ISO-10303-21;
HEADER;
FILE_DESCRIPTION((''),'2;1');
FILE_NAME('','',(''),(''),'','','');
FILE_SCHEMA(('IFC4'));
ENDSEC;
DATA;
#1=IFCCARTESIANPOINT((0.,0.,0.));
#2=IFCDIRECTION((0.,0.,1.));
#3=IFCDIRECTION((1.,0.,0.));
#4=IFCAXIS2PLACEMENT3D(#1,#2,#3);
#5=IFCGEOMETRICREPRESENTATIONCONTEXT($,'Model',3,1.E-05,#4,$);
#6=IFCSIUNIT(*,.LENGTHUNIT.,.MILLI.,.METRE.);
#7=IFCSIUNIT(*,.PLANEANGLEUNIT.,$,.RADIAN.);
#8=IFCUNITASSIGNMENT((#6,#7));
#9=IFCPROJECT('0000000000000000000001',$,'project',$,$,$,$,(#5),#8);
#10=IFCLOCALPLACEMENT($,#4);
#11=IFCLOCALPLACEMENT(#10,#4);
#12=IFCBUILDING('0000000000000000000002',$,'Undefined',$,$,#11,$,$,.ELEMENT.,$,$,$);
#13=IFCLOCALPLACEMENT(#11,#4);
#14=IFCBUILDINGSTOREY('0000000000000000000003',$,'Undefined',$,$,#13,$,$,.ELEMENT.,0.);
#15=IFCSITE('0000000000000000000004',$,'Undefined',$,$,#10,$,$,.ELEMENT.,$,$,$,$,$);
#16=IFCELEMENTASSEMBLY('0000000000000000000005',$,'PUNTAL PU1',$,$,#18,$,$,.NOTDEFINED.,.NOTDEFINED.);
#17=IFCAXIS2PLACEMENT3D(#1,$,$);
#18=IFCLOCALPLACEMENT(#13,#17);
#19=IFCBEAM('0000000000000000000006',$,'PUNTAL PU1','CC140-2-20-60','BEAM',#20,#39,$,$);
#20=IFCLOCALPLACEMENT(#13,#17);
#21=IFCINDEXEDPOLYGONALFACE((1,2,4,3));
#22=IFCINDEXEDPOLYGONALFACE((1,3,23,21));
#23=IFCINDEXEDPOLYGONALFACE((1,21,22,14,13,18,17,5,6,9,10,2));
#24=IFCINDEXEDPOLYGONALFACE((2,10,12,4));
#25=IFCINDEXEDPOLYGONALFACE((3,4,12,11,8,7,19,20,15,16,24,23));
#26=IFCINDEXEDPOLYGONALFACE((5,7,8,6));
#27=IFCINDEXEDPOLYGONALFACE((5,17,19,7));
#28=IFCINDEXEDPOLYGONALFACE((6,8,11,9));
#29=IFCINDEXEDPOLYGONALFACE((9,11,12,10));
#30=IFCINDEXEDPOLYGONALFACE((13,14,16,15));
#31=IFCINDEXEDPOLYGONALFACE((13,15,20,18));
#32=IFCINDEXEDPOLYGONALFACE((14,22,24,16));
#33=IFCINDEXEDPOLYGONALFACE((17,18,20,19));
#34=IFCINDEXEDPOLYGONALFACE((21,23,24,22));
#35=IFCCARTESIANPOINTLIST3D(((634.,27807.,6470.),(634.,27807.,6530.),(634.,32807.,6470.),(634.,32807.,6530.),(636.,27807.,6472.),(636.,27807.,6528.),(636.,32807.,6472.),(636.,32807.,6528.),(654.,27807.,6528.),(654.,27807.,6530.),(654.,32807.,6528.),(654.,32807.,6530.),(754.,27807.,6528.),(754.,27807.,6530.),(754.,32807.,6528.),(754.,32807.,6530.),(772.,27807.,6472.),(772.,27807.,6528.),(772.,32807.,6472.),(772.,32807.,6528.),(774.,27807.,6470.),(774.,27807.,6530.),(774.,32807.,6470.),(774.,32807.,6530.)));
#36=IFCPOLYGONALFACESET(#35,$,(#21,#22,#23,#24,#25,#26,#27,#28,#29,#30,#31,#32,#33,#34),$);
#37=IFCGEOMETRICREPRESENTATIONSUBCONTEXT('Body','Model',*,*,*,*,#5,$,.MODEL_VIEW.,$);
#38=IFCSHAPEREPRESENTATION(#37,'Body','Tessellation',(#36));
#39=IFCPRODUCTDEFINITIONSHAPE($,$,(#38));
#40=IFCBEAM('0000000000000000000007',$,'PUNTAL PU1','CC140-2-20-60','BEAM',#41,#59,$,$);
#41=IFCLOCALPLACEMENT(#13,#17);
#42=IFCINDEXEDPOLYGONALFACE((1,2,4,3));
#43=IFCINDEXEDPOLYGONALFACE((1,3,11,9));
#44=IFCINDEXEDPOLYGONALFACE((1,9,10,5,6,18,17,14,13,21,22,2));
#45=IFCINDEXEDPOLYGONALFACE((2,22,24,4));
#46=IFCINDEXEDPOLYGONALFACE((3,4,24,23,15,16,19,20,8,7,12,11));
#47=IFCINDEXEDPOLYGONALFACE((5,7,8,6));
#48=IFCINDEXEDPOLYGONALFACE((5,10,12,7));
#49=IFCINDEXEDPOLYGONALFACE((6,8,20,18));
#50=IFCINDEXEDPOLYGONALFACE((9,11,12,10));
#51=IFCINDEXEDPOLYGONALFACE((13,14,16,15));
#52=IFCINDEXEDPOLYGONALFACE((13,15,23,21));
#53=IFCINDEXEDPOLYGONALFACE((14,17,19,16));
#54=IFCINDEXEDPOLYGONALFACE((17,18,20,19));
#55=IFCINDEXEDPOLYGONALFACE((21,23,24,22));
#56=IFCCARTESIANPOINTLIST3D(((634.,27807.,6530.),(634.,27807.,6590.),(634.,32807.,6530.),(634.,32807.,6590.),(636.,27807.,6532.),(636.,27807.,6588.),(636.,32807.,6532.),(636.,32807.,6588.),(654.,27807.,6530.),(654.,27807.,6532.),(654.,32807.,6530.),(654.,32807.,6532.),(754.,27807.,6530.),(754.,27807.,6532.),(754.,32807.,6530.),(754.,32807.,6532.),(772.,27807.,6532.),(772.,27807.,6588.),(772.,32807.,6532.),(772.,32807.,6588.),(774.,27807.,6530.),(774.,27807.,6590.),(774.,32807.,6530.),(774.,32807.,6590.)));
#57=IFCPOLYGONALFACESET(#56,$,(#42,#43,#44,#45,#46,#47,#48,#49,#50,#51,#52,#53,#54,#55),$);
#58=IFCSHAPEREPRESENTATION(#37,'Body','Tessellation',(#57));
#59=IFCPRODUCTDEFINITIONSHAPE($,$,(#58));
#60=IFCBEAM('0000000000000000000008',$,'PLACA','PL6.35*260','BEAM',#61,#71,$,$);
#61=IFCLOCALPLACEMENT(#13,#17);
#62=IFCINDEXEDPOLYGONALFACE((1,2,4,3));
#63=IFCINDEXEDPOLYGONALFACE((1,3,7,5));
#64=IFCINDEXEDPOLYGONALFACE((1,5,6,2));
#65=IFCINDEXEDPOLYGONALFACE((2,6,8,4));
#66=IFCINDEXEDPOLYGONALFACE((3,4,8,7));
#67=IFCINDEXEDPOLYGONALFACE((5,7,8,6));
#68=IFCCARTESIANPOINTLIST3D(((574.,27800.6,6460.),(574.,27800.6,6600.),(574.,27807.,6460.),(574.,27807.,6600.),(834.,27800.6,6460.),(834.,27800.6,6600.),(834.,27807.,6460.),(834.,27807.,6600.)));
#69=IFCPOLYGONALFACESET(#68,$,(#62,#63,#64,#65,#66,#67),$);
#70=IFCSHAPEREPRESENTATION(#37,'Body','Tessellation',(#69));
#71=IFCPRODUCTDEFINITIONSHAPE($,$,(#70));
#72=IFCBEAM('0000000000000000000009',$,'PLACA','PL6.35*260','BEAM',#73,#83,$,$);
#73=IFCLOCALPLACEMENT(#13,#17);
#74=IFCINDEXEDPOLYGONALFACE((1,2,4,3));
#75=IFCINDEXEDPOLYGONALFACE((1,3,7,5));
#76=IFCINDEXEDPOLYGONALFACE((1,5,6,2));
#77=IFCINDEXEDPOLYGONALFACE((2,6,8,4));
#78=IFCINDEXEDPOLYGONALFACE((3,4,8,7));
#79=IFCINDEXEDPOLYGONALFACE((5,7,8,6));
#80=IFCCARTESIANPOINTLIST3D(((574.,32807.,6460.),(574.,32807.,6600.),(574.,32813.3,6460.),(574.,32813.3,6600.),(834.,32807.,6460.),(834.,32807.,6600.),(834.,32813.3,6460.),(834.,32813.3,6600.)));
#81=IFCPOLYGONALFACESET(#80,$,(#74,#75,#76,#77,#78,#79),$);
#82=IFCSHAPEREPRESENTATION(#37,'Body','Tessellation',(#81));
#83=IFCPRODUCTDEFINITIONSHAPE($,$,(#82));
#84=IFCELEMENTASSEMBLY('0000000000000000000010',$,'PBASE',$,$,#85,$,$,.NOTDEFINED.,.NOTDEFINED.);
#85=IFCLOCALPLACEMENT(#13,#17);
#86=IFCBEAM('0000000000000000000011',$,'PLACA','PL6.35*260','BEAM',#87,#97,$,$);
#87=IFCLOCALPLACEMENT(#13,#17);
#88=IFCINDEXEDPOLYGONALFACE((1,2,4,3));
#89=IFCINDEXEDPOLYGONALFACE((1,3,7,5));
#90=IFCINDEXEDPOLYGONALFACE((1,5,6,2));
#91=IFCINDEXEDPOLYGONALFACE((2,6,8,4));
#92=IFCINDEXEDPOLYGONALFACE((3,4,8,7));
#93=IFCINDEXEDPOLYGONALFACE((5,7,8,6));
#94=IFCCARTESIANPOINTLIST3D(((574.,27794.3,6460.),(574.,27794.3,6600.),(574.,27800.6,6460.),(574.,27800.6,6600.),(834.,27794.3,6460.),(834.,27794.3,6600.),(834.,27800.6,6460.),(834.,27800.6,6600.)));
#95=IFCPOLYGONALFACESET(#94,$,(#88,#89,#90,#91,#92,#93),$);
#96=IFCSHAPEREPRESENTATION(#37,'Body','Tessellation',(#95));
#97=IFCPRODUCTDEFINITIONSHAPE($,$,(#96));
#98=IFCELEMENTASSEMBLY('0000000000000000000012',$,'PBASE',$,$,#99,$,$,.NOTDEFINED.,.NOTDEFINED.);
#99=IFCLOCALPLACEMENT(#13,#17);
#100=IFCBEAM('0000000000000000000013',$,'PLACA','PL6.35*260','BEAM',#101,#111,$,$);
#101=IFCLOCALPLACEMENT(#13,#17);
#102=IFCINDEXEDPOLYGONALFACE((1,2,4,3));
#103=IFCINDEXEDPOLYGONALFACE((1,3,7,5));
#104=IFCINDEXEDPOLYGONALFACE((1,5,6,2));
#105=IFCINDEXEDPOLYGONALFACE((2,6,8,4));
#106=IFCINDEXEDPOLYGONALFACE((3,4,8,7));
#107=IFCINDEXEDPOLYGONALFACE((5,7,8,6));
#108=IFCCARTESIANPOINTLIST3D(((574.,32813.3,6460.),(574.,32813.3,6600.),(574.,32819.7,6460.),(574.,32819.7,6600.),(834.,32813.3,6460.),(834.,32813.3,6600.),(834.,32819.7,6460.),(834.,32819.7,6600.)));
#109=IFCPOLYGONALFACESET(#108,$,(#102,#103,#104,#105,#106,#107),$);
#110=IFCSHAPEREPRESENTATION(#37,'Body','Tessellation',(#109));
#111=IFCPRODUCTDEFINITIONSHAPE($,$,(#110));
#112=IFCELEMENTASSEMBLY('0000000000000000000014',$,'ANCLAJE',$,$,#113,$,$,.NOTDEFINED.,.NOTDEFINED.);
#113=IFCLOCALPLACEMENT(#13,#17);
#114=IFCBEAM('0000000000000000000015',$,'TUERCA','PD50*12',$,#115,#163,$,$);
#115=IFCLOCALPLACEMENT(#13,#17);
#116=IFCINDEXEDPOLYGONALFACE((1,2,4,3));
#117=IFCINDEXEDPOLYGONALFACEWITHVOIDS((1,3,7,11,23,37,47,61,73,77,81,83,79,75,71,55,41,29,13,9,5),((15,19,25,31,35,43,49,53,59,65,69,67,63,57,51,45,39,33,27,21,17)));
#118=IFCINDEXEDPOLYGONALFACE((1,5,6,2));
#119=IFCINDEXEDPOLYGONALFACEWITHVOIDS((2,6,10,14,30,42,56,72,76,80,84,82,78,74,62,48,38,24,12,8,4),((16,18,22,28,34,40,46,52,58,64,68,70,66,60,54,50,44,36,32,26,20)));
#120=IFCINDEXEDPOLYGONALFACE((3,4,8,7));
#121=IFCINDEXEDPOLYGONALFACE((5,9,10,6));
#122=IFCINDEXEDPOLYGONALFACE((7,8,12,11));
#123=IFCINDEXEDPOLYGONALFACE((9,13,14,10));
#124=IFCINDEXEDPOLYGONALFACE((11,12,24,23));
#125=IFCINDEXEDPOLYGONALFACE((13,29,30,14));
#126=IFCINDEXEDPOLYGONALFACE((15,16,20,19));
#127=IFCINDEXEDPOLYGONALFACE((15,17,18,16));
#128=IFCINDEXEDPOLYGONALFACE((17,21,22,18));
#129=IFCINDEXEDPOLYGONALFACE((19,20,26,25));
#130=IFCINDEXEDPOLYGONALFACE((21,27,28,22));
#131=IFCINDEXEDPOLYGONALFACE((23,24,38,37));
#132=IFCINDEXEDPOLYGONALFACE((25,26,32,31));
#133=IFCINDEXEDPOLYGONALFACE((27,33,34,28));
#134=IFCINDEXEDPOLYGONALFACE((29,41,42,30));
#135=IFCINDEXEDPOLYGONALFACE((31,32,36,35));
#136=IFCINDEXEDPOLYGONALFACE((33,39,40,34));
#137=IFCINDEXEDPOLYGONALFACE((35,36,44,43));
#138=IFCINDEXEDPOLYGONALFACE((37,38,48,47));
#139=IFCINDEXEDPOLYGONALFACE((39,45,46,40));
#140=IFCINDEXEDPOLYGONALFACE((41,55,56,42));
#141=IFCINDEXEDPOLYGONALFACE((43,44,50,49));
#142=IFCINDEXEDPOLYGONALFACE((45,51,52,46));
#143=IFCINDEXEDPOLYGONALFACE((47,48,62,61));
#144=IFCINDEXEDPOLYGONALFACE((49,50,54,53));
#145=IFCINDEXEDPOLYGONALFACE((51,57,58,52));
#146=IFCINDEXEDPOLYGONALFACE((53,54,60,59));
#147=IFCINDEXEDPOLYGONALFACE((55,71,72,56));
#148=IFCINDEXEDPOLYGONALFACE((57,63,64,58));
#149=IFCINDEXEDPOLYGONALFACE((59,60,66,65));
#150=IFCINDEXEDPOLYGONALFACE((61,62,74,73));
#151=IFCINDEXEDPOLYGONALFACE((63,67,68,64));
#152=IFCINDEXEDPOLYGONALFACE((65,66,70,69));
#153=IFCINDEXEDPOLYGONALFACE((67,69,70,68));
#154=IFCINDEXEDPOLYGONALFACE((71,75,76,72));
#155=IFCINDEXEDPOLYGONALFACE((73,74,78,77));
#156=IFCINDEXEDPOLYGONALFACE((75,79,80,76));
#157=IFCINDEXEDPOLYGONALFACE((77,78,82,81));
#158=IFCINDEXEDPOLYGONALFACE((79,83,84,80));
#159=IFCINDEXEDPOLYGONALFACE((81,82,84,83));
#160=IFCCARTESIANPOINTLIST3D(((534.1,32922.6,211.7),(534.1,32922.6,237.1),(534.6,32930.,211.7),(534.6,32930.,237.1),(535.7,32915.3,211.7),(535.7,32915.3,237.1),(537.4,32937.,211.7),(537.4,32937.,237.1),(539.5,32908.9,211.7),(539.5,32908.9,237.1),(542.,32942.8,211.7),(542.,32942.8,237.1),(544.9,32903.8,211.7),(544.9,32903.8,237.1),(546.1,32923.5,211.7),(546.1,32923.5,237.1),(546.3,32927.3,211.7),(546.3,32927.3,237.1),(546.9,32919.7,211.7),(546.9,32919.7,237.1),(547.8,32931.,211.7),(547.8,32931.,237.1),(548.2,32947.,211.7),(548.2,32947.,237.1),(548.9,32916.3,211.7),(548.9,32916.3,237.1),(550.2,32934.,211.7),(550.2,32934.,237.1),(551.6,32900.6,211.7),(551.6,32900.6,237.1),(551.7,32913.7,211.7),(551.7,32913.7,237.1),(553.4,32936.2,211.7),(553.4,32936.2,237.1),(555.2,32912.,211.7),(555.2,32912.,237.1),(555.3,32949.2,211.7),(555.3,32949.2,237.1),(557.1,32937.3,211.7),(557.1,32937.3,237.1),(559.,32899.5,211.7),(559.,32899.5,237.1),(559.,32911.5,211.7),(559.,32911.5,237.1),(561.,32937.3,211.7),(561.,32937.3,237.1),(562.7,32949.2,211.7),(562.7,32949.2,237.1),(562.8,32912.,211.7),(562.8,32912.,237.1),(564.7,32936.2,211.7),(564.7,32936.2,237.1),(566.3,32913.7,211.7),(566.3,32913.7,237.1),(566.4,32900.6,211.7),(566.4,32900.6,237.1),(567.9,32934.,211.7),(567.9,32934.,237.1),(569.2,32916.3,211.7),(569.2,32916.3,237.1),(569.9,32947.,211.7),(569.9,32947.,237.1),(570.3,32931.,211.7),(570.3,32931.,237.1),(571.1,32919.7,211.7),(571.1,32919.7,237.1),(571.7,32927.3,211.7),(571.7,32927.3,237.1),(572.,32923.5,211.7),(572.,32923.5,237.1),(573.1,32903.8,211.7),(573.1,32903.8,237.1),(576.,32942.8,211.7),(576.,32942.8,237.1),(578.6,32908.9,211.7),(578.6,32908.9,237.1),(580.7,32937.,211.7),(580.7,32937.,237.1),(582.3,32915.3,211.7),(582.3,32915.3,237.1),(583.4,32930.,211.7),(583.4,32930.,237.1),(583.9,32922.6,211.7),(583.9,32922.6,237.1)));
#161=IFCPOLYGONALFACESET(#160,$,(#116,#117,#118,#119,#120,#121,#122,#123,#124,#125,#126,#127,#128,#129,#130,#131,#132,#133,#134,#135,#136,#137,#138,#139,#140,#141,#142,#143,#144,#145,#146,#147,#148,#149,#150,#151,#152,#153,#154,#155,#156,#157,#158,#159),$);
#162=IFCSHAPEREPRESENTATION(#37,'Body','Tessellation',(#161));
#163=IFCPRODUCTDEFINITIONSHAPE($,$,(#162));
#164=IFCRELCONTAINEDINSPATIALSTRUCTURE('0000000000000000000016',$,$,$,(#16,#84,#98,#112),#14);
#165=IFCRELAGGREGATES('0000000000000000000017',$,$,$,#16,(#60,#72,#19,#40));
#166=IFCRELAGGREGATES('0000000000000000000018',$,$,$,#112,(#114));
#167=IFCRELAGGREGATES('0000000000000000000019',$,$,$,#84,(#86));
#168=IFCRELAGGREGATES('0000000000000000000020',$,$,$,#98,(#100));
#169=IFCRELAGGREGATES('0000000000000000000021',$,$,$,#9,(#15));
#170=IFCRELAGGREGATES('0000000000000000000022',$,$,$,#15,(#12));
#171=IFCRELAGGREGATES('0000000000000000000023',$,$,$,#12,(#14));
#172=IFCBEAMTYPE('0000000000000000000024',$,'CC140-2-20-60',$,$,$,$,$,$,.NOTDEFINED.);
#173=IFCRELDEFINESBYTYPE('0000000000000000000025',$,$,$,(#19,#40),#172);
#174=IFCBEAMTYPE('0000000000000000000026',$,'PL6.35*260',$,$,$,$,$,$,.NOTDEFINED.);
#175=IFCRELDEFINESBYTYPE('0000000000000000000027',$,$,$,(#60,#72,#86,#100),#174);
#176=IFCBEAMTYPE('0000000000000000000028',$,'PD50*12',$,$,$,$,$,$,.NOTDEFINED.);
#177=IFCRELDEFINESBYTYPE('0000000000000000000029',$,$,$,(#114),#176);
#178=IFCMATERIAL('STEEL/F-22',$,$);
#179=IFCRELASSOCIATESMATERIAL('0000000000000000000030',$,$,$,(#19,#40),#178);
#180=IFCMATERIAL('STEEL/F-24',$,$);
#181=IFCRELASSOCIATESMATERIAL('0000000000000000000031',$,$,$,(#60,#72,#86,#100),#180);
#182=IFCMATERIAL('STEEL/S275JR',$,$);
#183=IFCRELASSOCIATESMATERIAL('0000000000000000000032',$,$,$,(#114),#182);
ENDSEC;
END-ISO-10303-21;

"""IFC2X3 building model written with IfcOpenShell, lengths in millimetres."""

from ifc_helpers import new_model, si_unit, frame, origin_with_axes, origin_2d_with_axis, place, context, subcontext, project, spatial, rectangle, hollow_circle, c_section, extrude, material, type_object, element, aggregate, save


model = new_model("IFC2X3")

# Units and contexts
model_context = context("Model", 3, precision=1e-05, world=origin_with_axes())
body_context = subcontext(model_context, "Body", "Model", "MODEL_VIEW")
ifc_project = project(units=[si_unit("LENGTHUNIT", "METRE", prefix="MILLI"), si_unit("PLANEANGLEUNIT", "RADIAN")], contexts=[model_context])

# Site, building, storey
site_placement = place(None, origin_with_axes())
site = spatial("IfcSite", under=ifc_project, at=site_placement, Name="Undefined", CompositionType="ELEMENT")
building_placement = place(site_placement, origin_with_axes())
building = spatial("IfcBuilding", under=site, at=building_placement, Name="Undefined", CompositionType="ELEMENT")
storey_placement = place(building_placement, origin_with_axes())
storey = spatial("IfcBuildingStorey", under=building, at=storey_placement, Name="Undefined", CompositionType="ELEMENT", Elevation=0.0)

# Element assembly, beams
assembly_1_placement = place(storey_placement, origin_with_axes())
assembly_1 = element("IfcElementAssembly", 1, at=assembly_1_placement, inside=storey, Name="PUNTAL PU1", AssemblyPlace="NOTDEFINED", PredefinedType="NOTDEFINED")
ifc_material_1 = material(Name="STEEL/F-22")
beam_type_1 = type_object("IfcBeamType", Name="CC140-2-20-60", PredefinedType="NOTDEFINED")
beam_1_placement = place(assembly_1_placement, frame((704.0, 32807.0, 6500.0), z_axis=(1.0, 0.0, 0.0), x_axis=(0.0, -1.0, 0.0)))
beam_1 = element("IfcBeam", 2, at=beam_1_placement, type_object=beam_type_1, material=ifc_material_1, Name="PUNTAL PU1", Description="CC140-2-20-60", ObjectType="BEAM", context=body_context, shape_type="SweptSolid", body=[
    extrude(c_section(Depth=140.0, Width=60.0, WallThickness=2.0, Girth=20.0, at=origin_2d_with_axis()), frame((5000.0, 0.0, 0.0), z_axis=(-1.0, 0.0, 0.0), x_axis=(0.0, -1.0, 0.0)), (0.0, 0.0, 1.0), 5000.0),
])
beam_2_placement = place(assembly_1_placement, frame((704.0, 32807.0, 6560.0), z_axis=(-1.0, 0.0, 0.0), x_axis=(0.0, -1.0, 0.0)))
beam_2 = element("IfcBeam", 3, at=beam_2_placement, type_object=beam_type_1, material=ifc_material_1, Name="PUNTAL PU1", Description="CC140-2-20-60", ObjectType="BEAM", context=body_context, shape_type="SweptSolid", body=[
    extrude(c_section(Depth=140.0, Width=60.0, WallThickness=2.0, Girth=20.0, at=origin_2d_with_axis()), frame((5000.0, 0.0, 0.0), z_axis=(-1.0, 0.0, 0.0), x_axis=(0.0, -1.0, 0.0)), (0.0, 0.0, 1.0), 5000.0),
])
ifc_material_2 = material(Name="STEEL/F-24")
beam_type_2 = type_object("IfcBeamType", Name="PL6.35*260", PredefinedType="NOTDEFINED")
beam_3_placement = place(assembly_1_placement, frame((704.0, 27803.8, 6460.0), z_axis=(1.0, 0.0, 0.0), x_axis=(0.0, 0.0, 1.0)))
beam_3 = element("IfcBeam", 4, at=beam_3_placement, type_object=beam_type_2, material=ifc_material_2, Name="PLACA", Description="PL6.35*260", ObjectType="BEAM", context=body_context, shape_type="SweptSolid", body=[
    extrude(rectangle(XDim=6.3, YDim=260.0, at=origin_2d_with_axis()), frame((140.0, 0.0, 0.0), z_axis=(-1.0, 0.0, 0.0), x_axis=(0.0, -1.0, 0.0)), (0.0, 0.0, 1.0), 140.0),
])
beam_4_placement = place(assembly_1_placement, frame((704.0, 32810.1, 6460.0), z_axis=(-1.0, 0.0, 0.0), x_axis=(0.0, 0.0, 1.0)))
beam_4 = element("IfcBeam", 5, at=beam_4_placement, type_object=beam_type_2, material=ifc_material_2, Name="PLACA", Description="PL6.35*260", ObjectType="BEAM", context=body_context, shape_type="SweptSolid", body=[
    extrude(rectangle(XDim=6.3, YDim=260.0, at=origin_2d_with_axis()), frame((140.0, 0.0, 0.0), z_axis=(-1.0, 0.0, 0.0), x_axis=(0.0, -1.0, 0.0)), (0.0, 0.0, 1.0), 140.0),
])
aggregate(assembly_1, [beam_3, beam_4, beam_1, beam_2])

# Element assemblies, beams
assembly_2_placement = place(storey_placement, origin_with_axes())
assembly_2 = element("IfcElementAssembly", 6, at=assembly_2_placement, inside=storey, Name="PBASE", AssemblyPlace="NOTDEFINED", PredefinedType="NOTDEFINED")
beam_5_placement = place(assembly_2_placement, frame((704.0, 27797.4, 6460.0), z_axis=(1.0, 0.0, 0.0), x_axis=(0.0, 0.0, 1.0)))
beam_5 = element("IfcBeam", 7, at=beam_5_placement, type_object=beam_type_2, material=ifc_material_2, Name="PLACA", Description="PL6.35*260", ObjectType="BEAM", context=body_context, shape_type="SweptSolid", body=[
    extrude(rectangle(XDim=6.3, YDim=260.0, at=origin_2d_with_axis()), frame((140.0, 0.0, 0.0), z_axis=(-1.0, 0.0, 0.0), x_axis=(0.0, -1.0, 0.0)), (0.0, 0.0, 1.0), 140.0),
])
assembly_3_placement = place(storey_placement, origin_with_axes())
assembly_3 = element("IfcElementAssembly", 8, at=assembly_3_placement, inside=storey, Name="PBASE", AssemblyPlace="NOTDEFINED", PredefinedType="NOTDEFINED")
beam_6_placement = place(assembly_3_placement, frame((704.0, 32816.5, 6460.0), z_axis=(-1.0, 0.0, 0.0), x_axis=(0.0, 0.0, 1.0)))
beam_6 = element("IfcBeam", 9, at=beam_6_placement, type_object=beam_type_2, material=ifc_material_2, Name="PLACA", Description="PL6.35*260", ObjectType="BEAM", context=body_context, shape_type="SweptSolid", body=[
    extrude(rectangle(XDim=6.3, YDim=260.0, at=origin_2d_with_axis()), frame((140.0, 0.0, 0.0), z_axis=(-1.0, 0.0, 0.0), x_axis=(0.0, -1.0, 0.0)), (0.0, 0.0, 1.0), 140.0),
])

# Element assembly, beam
assembly_4_placement = place(storey_placement, origin_with_axes())
assembly_4 = element("IfcElementAssembly", 10, at=assembly_4_placement, inside=storey, Name="ANCLAJE", AssemblyPlace="NOTDEFINED", PredefinedType="NOTDEFINED")
ifc_material_3 = material(Name="STEEL/S275JR")
beam_type_3 = type_object("IfcBeamType", Name="PD50*12", PredefinedType="NOTDEFINED")
beam_7_placement = place(assembly_4_placement, frame((559.0, 32924.5, 237.1), z_axis=(1.0, 0.0, 0.0), x_axis=(0.0, 0.0, -1.0)))
beam_7 = element("IfcBeam", 11, at=beam_7_placement, type_object=beam_type_3, material=ifc_material_3, Name="TUERCA", Description="PD50*12", context=body_context, shape_type="SweptSolid", body=[
    extrude(hollow_circle(Radius=25.0, WallThickness=12.0, at=origin_2d_with_axis()), frame((25.4, 0.0, 0.0), z_axis=(-1.0, 0.0, 0.0), x_axis=(0.0, -1.0, 0.0)), (0.0, 0.0, 1.0), 25.4),
])
aggregate(assembly_4, [beam_7])

aggregate(assembly_2, [beam_5])
aggregate(assembly_3, [beam_6])

save(model, "model.ifc")
